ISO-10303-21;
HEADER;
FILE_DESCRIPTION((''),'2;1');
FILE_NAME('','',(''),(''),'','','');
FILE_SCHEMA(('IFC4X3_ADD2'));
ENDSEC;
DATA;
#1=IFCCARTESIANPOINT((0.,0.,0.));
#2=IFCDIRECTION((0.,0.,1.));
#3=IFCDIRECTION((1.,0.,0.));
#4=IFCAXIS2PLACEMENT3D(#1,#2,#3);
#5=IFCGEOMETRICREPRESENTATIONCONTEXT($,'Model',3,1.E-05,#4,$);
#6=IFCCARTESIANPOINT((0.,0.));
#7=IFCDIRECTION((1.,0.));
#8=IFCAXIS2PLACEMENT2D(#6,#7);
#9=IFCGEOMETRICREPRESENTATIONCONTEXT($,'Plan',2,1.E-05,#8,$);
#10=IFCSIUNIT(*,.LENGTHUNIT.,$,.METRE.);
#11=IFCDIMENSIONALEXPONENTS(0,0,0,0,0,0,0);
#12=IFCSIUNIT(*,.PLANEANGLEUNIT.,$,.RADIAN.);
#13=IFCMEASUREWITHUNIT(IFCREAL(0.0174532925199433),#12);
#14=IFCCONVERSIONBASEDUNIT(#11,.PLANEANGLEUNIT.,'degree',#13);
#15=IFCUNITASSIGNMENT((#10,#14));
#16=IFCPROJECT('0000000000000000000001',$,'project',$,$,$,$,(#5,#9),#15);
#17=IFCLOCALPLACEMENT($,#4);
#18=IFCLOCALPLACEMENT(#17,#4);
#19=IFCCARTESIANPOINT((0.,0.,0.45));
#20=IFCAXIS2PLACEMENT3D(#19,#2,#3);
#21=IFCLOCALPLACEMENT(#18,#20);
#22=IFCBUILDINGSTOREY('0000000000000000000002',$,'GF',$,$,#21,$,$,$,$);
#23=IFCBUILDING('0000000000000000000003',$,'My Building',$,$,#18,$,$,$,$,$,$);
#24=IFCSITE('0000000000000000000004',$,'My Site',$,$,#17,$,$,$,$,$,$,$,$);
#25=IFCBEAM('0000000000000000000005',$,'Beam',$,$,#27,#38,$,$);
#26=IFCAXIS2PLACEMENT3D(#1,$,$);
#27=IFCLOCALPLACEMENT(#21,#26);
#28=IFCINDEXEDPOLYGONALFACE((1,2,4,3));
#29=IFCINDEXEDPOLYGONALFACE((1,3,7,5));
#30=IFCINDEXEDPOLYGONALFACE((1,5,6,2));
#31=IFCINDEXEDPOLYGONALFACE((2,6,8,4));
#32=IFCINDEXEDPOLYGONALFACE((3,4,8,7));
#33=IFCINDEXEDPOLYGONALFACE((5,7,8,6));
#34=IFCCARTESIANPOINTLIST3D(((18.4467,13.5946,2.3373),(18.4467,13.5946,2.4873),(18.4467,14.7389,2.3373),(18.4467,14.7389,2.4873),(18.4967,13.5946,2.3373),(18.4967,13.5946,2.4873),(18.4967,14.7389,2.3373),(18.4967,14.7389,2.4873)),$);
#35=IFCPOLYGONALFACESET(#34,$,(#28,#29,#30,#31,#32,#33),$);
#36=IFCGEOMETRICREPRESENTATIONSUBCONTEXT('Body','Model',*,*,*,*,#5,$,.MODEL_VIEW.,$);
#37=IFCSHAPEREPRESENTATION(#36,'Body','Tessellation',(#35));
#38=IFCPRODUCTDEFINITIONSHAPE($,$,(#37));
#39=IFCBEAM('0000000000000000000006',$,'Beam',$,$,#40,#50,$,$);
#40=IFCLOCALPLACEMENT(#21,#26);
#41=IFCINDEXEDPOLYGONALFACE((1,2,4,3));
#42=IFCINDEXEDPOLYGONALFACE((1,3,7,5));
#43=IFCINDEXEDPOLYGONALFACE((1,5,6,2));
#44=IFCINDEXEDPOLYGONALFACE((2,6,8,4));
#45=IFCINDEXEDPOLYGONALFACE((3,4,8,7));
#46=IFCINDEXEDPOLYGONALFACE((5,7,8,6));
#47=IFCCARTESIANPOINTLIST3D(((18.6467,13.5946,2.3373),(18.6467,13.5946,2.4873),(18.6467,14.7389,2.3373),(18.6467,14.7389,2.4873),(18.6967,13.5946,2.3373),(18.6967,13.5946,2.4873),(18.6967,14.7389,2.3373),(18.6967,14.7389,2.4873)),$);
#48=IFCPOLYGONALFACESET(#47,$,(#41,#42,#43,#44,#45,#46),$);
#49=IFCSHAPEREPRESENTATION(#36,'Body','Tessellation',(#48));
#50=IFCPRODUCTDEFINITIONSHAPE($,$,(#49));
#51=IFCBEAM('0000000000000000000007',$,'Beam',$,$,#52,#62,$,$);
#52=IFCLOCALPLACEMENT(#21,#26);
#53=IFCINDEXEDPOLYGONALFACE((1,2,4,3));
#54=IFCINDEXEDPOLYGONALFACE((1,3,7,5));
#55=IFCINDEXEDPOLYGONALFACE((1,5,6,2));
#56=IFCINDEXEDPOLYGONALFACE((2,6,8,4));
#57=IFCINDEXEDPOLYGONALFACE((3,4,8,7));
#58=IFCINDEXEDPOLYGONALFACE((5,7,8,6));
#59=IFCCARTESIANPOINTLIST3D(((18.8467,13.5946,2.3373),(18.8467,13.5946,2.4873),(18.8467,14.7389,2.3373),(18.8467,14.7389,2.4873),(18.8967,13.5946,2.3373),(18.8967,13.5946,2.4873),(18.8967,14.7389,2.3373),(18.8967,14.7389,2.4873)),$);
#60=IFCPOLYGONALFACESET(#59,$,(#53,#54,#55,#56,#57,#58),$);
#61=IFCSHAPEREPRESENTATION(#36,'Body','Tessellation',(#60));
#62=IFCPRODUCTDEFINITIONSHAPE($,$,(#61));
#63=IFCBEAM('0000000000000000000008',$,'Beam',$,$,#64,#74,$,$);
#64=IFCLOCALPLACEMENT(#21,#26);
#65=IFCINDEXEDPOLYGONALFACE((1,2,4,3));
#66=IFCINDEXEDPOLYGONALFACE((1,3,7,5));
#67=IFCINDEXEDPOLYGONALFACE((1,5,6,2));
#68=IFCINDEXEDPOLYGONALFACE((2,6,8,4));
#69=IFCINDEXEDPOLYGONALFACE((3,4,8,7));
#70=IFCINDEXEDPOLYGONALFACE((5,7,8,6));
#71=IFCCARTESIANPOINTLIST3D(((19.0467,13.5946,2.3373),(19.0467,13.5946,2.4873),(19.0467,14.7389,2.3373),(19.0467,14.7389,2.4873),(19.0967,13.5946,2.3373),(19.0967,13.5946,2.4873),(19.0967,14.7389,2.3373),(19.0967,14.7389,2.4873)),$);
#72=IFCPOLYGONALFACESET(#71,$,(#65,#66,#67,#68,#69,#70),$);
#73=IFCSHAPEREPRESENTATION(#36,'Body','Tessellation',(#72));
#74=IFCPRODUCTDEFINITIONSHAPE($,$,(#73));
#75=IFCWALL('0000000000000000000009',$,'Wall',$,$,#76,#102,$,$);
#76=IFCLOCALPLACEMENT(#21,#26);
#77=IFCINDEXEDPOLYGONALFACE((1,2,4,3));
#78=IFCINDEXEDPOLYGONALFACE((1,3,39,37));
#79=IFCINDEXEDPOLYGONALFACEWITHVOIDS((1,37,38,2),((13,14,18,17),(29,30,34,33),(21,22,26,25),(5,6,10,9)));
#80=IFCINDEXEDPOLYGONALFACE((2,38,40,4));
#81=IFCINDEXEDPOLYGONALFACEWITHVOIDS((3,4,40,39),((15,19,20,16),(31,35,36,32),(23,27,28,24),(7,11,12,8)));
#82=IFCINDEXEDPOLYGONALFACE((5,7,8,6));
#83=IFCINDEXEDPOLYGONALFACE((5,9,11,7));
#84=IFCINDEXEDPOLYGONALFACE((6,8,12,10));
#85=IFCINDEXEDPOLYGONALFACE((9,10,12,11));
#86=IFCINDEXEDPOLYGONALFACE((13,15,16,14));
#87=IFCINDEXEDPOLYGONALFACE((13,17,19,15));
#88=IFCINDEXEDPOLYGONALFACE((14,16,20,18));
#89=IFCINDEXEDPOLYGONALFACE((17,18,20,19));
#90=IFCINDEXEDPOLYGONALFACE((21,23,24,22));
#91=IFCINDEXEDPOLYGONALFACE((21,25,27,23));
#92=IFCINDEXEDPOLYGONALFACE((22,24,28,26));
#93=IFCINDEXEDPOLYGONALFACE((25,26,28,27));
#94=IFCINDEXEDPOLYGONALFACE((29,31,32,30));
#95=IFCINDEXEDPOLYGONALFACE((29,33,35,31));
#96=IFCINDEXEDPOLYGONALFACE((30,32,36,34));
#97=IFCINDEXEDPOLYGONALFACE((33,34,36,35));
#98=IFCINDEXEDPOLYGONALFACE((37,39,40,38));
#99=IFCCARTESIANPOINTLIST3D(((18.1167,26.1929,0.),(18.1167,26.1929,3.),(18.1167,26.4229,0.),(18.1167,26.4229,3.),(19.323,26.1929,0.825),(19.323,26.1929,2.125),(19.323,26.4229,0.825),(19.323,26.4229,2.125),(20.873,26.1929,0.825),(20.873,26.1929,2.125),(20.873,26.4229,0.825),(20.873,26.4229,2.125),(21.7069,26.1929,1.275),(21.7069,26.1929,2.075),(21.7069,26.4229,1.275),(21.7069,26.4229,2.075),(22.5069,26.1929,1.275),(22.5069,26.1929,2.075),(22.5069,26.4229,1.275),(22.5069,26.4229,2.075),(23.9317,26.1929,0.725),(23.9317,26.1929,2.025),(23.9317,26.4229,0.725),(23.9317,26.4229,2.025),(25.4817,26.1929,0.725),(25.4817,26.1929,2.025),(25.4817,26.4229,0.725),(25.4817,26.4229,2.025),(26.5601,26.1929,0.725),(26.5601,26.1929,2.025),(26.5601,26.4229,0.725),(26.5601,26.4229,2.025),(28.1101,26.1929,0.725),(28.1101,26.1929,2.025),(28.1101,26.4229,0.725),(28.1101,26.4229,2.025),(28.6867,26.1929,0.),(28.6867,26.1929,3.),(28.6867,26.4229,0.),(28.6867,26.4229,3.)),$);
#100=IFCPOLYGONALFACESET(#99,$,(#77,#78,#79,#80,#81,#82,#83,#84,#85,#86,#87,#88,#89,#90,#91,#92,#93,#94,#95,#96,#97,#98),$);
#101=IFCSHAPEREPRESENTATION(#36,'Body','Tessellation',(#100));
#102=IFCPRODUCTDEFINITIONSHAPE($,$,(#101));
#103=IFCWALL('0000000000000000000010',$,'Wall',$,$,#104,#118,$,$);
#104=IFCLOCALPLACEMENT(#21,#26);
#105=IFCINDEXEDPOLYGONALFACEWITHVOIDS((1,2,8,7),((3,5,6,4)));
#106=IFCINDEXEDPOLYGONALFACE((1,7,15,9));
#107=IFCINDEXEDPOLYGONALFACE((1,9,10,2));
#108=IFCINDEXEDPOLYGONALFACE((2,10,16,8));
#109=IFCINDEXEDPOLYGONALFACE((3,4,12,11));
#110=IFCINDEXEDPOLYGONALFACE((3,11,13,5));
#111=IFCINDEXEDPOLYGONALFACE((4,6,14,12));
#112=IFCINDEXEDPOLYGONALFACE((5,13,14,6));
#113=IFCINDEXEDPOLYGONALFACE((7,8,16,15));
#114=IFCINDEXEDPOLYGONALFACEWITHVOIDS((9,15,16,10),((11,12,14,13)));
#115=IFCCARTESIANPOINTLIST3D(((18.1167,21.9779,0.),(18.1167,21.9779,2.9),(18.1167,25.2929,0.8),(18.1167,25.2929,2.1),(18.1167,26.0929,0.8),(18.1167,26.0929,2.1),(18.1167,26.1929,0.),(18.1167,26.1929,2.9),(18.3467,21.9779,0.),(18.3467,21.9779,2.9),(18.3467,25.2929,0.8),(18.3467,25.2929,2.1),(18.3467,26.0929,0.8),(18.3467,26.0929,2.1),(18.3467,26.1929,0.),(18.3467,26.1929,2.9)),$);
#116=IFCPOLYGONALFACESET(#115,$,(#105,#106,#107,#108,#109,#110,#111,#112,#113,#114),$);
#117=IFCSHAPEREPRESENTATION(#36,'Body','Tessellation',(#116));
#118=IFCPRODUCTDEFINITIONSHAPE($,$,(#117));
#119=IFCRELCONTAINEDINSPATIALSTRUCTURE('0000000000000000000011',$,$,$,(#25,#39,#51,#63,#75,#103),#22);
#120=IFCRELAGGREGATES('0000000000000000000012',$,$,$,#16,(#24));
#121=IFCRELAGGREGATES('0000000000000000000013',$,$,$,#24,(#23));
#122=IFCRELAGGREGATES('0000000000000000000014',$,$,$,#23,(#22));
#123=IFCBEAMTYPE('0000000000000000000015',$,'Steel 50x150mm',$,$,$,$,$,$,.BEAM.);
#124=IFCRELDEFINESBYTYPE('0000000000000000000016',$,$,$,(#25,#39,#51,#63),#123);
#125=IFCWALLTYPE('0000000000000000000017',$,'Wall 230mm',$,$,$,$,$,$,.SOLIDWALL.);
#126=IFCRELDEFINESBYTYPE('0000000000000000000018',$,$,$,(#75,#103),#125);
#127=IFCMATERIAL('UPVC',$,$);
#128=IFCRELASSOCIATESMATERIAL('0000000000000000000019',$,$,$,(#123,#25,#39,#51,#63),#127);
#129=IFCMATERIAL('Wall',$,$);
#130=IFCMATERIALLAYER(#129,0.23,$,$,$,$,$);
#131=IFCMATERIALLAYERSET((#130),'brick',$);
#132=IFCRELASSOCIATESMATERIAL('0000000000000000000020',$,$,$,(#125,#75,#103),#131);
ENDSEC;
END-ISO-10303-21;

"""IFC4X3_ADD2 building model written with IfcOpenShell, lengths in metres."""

from ifc_helpers import new_model, entity, si_unit, converted_unit, frame, origin_with_axes, origin_2d_with_axis, place, context, subcontext, project, spatial, line, indexed_curve, rectangle, outline, extrude, source, transform, mapped, material, layer, layer_set, layer_usage, material_profile, profile_set, profile_usage, type_object, element, save


model = new_model("IFC4X3_ADD2")

# Units and contexts
model_context = context("Model", 3, precision=1e-05, world=origin_with_axes())
plan_context = context("Plan", 2, precision=1e-05, world=origin_2d_with_axis())
body_context_1 = subcontext(model_context, "Body", "Model", "MODEL_VIEW")
ifc_project = project(units=[si_unit("LENGTHUNIT", "METRE"), converted_unit("PLANEANGLEUNIT", "degree", entity("IfcReal", 0.0174532925199433), si_unit("PLANEANGLEUNIT", "RADIAN"), dimensions=[0, 0, 0, 0, 0, 0, 0])], contexts=[model_context, plan_context])

# Site, building, storey
site_placement = place(None, origin_with_axes())
site = spatial("IfcSite", under=ifc_project, at=site_placement, Name="My Site")
building_placement = place(site_placement, origin_with_axes())
building = spatial("IfcBuilding", under=site, at=building_placement, Name="My Building")
storey_placement = place(building_placement, frame((0.0, 0.0, 0.45), z_axis=(0.0, 0.0, 1.0), x_axis=(1.0, 0.0, 0.0)))
storey = spatial("IfcBuildingStorey", under=building, at=storey_placement, Name="GF")

# Beams
ifc_material_1 = material(Name="UPVC")
ifc_material_profile = material_profile(ifc_material_1, rectangle(XDim=0.05, YDim=0.15))
ifc_profile_set = profile_set([ifc_material_profile])
ifc_profile_usage_1 = profile_usage(ifc_profile_set)
beam_type = type_object("IfcBeamType", Name="Steel 50x150mm", PredefinedType="BEAM", material=ifc_profile_set)
beam_1_placement = place(storey_placement, frame((18.4717, 14.7389, 2.4123), z_axis=(0.0, -1.0, 0.0), x_axis=(1.0, 0.0, 0.0)))
element("IfcBeam", 1, at=beam_1_placement, inside=storey, type_object=beam_type, material=ifc_profile_usage_1, Name="Beam", context=body_context_1, shape_type="SweptSolid", body=[
    extrude(rectangle(XDim=0.05, YDim=0.15), origin_with_axes(), (0.0, 0.0, 1.0), 1.1444),
])
ifc_profile_usage_2 = profile_usage(ifc_profile_set)
beam_2_placement = place(storey_placement, frame((18.6717, 14.7389, 2.4123), z_axis=(0.0, -1.0, 0.0), x_axis=(1.0, 0.0, 0.0)))
element("IfcBeam", 2, at=beam_2_placement, inside=storey, type_object=beam_type, material=ifc_profile_usage_2, Name="Beam", context=body_context_1, shape_type="SweptSolid", body=[
    extrude(rectangle(XDim=0.05, YDim=0.15), origin_with_axes(), (0.0, 0.0, 1.0), 1.1444),
])
ifc_profile_usage_3 = profile_usage(ifc_profile_set)
beam_3_placement = place(storey_placement, frame((18.8717, 14.7389, 2.4123), z_axis=(0.0, -1.0, 0.0), x_axis=(1.0, 0.0, 0.0)))
element("IfcBeam", 3, at=beam_3_placement, inside=storey, type_object=beam_type, material=ifc_profile_usage_3, Name="Beam", context=body_context_1, shape_type="SweptSolid", body=[
    extrude(rectangle(XDim=0.05, YDim=0.15), origin_with_axes(), (0.0, 0.0, 1.0), 1.1444),
])
ifc_profile_usage_4 = profile_usage(ifc_profile_set)
beam_4_placement = place(storey_placement, frame((19.0717, 14.7389, 2.4123), z_axis=(0.0, -1.0, 0.0), x_axis=(1.0, 0.0, 0.0)))
element("IfcBeam", 4, at=beam_4_placement, inside=storey, type_object=beam_type, material=ifc_profile_usage_4, Name="Beam", context=body_context_1, shape_type="SweptSolid", body=[
    extrude(rectangle(XDim=0.05, YDim=0.15), origin_with_axes(), (0.0, 0.0, 1.0), 1.1444),
])

# Wall, openings
ifc_material_2 = material(Name="Wall")
ifc_layer = layer(ifc_material_2, 0.23)
ifc_layer_set = layer_set([ifc_layer], Name="brick")
ifc_layer_usage_1 = layer_usage(ifc_layer_set, "AXIS2", "POSITIVE", 0.0)
wall_type = type_object("IfcWallType", Name="Wall 230mm", PredefinedType="SOLIDWALL", material=ifc_layer_set)
wall_1_placement = place(storey_placement, frame((18.1167, 26.1929, 0.0), z_axis=(0.0, 0.0, 1.0), x_axis=(1.0, 0.0, 0.0)))
wall_1 = element("IfcWall", 5, at=wall_1_placement, inside=storey, type_object=wall_type, material=ifc_layer_usage_1, Name="Wall", context=body_context_1, shape_type="SweptSolid", body=[
    extrude(outline(indexed_curve([(0.0, 0.0), (0.0, 0.23), (10.57, 0.23), (10.57, 0.0), (0.0, 0.0)], self_intersect=False)), origin_with_axes(), (0.0, 0.0, 1.0), 3.0),
])
shared_shape_1 = source(origin_with_axes(), body_context_1, "Body", "SweptSolid", [
    extrude(outline(indexed_curve([(0.0, 0.0), (1.55, 0.0), (1.55, 1.3), (0.0, 1.3)], segments=[line(1, 2, 3, 4, 1)])), frame((-0.775, -0.6, 0.0), z_axis=(0.0, -1.0, 0.0), x_axis=(1.0, 0.0, 0.0)), (0.0, 0.0, -1.0), 1.2),
])
opening_1_placement = place(wall_1_placement, frame((1.9813, 0.0, 0.825), z_axis=(0.0, 0.0, 1.0), x_axis=(1.0, 0.0, 0.0)))
element("IfcOpeningElement", 6, at=opening_1_placement, cuts=wall_1, PredefinedType="OPENING", context=body_context_1, shape_type="MappedRepresentation", body=[
    mapped(shared_shape_1, transform((0.0, 0.0, 0.0), x_axis=(1.0, 0.0, 0.0), y_axis=(0.0, 1.0, 0.0), z_axis=(0.0, 0.0, 1.0), scale=1.0)),
])
opening_2_placement = place(wall_1_placement, frame((6.59, 0.07, 0.725), z_axis=(0.0, 0.0, 1.0), x_axis=(-1.0, 0.0, 0.0)))
element("IfcOpeningElement", 7, at=opening_2_placement, cuts=wall_1, PredefinedType="OPENING", context=body_context_1, shape_type="MappedRepresentation", body=[
    mapped(shared_shape_1, transform((0.0, 0.0, 0.0), x_axis=(1.0, 0.0, 0.0), y_axis=(0.0, 1.0, 0.0), z_axis=(0.0, 0.0, 1.0), scale=1.0)),
])
opening_3_placement = place(wall_1_placement, frame((9.2184, 0.0, 0.725), z_axis=(0.0, 0.0, 1.0), x_axis=(1.0, 0.0, 0.0)))
element("IfcOpeningElement", 8, at=opening_3_placement, cuts=wall_1, PredefinedType="OPENING", context=body_context_1, shape_type="MappedRepresentation", body=[
    mapped(shared_shape_1, transform((0.0, 0.0, 0.0), x_axis=(1.0, 0.0, 0.0), y_axis=(0.0, 1.0, 0.0), z_axis=(0.0, 0.0, 1.0), scale=1.0)),
])
shared_shape_2 = source(origin_with_axes(), body_context_1, "Body", "SweptSolid", [
    extrude(outline(indexed_curve([(0.0, 0.8), (0.0, 0.0), (0.8, 0.0), (0.8, 0.8)], segments=[line(4, 1), line(1, 2), line(2, 3), line(3, 4)], self_intersect=False)), frame((-0.4, -0.6, 0.0), z_axis=(0.0, -1.0, 0.0), x_axis=(1.0, 0.0, 0.0)), (0.0, 0.0, -1.0), 1.2),
])
opening_4_placement = place(wall_1_placement, frame((3.9902, 0.0, 1.275), z_axis=(0.0, 0.0, 1.0), x_axis=(1.0, 0.0, 0.0)))
element("IfcOpeningElement", 9, at=opening_4_placement, cuts=wall_1, PredefinedType="OPENING", context=body_context_1, shape_type="MappedRepresentation", body=[
    mapped(shared_shape_2, transform((0.0, 0.0, 0.0), x_axis=(1.0, 0.0, 0.0), y_axis=(0.0, 1.0, 0.0), z_axis=(0.0, 0.0, 1.0), scale=1.0)),
])

# Wall, opening
ifc_layer_usage_2 = layer_usage(ifc_layer_set, "AXIS2", "POSITIVE", 0.0)
wall_2_placement = place(storey_placement, frame((18.3467, 21.9779, 0.0), z_axis=(0.0, 0.0, 1.0), x_axis=(0.0, 1.0, 0.0)))
wall_2 = element("IfcWall", 10, at=wall_2_placement, inside=storey, type_object=wall_type, material=ifc_layer_usage_2, Name="Wall", context=body_context_1, shape_type="SweptSolid", body=[
    extrude(outline(indexed_curve([(0.0, 0.0), (0.0, 0.23), (4.215, 0.23), (4.215, 0.0), (0.0, 0.0)], self_intersect=False)), origin_with_axes(), (0.0, 0.0, 1.0), 2.9),
])
shared_shape_3 = source(origin_with_axes(), body_context_1, "Body", "SweptSolid", [
    extrude(outline(indexed_curve([(0.0, 0.0), (0.8, 0.0), (0.8, 1.3), (0.0, 1.3)], segments=[line(1, 2, 3, 4, 1)])), frame((-0.4, -0.6, 0.0), z_axis=(0.0, -1.0, 0.0), x_axis=(1.0, 0.0, 0.0)), (0.0, 0.0, -1.0), 1.2),
])
opening_5_placement = place(wall_2_placement, frame((3.715, 0.0, 0.8), z_axis=(0.0, 0.0, 1.0), x_axis=(1.0, 0.0, 0.0)))
element("IfcOpeningElement", 11, at=opening_5_placement, cuts=wall_2, PredefinedType="OPENING", context=body_context_1, shape_type="MappedRepresentation", body=[
    mapped(shared_shape_3, transform((0.0, 0.0, 0.0), x_axis=(1.0, 0.0, 0.0), y_axis=(0.0, 1.0, 0.0), z_axis=(0.0, 0.0, 1.0), scale=1.0)),
])

save(model, "model.ifc")
